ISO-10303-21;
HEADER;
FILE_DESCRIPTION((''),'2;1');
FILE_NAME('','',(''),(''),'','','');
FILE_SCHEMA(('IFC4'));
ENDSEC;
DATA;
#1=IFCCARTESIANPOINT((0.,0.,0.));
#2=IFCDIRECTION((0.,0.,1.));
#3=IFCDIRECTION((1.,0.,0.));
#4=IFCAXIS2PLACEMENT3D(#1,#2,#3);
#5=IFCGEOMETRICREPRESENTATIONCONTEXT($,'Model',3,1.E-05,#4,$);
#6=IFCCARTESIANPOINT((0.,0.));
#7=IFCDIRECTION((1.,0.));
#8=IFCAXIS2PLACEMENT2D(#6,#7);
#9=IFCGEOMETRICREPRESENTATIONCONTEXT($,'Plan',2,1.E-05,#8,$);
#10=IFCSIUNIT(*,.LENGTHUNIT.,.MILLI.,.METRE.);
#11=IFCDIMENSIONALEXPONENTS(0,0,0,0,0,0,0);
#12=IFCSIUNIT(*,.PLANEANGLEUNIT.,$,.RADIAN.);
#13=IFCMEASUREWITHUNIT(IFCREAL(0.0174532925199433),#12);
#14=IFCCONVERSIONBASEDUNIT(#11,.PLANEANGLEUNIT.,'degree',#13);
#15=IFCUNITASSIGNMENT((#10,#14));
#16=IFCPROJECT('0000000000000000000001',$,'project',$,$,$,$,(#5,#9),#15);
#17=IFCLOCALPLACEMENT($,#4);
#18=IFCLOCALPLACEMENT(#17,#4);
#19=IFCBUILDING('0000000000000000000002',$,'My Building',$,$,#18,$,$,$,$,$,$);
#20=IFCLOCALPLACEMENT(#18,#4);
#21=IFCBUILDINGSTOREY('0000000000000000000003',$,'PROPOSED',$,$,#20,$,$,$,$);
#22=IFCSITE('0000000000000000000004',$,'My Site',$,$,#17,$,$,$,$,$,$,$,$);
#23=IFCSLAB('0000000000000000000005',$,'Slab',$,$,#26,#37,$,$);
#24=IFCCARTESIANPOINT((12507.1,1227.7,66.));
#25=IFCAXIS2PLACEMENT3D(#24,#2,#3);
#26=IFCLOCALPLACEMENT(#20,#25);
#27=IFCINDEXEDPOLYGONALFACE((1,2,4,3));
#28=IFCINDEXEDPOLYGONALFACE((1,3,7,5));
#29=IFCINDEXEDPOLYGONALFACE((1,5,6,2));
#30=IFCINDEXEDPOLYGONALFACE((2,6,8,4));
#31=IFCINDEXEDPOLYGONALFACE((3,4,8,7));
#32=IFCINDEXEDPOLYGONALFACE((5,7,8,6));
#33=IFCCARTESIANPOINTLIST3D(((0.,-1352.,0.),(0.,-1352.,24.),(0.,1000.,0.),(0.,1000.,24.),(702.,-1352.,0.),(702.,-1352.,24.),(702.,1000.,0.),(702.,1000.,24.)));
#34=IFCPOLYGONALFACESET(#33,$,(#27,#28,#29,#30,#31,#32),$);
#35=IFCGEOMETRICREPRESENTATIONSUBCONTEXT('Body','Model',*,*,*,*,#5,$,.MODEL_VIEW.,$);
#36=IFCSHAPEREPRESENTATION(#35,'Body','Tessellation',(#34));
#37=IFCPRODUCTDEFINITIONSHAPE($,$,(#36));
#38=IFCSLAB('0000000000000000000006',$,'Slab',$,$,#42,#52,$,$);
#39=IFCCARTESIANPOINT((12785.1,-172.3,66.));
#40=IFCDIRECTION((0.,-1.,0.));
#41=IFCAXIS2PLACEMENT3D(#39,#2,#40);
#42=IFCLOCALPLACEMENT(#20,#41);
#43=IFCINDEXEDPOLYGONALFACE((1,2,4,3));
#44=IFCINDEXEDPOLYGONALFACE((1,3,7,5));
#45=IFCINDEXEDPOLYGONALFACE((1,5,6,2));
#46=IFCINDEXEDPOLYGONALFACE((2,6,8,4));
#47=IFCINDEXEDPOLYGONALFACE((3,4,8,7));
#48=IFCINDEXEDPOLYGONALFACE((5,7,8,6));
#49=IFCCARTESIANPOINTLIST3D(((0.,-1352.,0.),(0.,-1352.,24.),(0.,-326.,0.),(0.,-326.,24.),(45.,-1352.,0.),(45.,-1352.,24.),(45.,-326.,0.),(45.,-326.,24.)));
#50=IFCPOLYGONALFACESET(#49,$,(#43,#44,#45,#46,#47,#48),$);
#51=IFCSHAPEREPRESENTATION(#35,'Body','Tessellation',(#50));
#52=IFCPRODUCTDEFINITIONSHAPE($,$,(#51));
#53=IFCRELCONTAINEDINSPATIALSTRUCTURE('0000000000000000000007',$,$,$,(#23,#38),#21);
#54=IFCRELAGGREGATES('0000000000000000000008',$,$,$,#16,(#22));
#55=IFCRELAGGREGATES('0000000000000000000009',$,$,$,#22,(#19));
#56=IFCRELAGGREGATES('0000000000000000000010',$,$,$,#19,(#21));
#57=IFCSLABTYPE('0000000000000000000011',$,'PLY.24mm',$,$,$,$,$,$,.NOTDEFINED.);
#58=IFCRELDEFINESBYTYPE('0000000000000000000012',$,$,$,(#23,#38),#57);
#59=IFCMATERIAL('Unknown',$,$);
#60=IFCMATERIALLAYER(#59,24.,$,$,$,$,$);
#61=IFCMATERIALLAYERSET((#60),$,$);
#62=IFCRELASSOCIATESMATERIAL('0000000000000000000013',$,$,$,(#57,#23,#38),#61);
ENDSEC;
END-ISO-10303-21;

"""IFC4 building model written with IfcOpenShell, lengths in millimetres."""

from ifc_helpers import new_model, entity, si_unit, converted_unit, frame, origin_with_axes, origin_2d_with_axis, place, context, subcontext, project, spatial, line, indexed_curve, outline, extrude, material, layer, layer_set, layer_usage, type_object, element, save


model = new_model("IFC4")

# Units and contexts
model_context = context("Model", 3, precision=1e-05, world=origin_with_axes())
plan_context = context("Plan", 2, precision=1e-05, world=origin_2d_with_axis())
body_context = subcontext(model_context, "Body", "Model", "MODEL_VIEW")
ifc_project = project(units=[si_unit("LENGTHUNIT", "METRE", prefix="MILLI"), converted_unit("PLANEANGLEUNIT", "degree", entity("IfcReal", 0.0174532925199433), si_unit("PLANEANGLEUNIT", "RADIAN"), dimensions=[0, 0, 0, 0, 0, 0, 0])], contexts=[model_context, plan_context])

# Site, building, storey
site_placement = place(None, origin_with_axes())
site = spatial("IfcSite", under=ifc_project, at=site_placement, Name="My Site")
building_placement = place(site_placement, origin_with_axes())
building = spatial("IfcBuilding", under=site, at=building_placement, Name="My Building")
storey_placement = place(building_placement, origin_with_axes())
storey = spatial("IfcBuildingStorey", under=building, at=storey_placement, Name="PROPOSED")

# Slabs
ifc_material = material(Name="Unknown")
ifc_layer_1 = layer(ifc_material, 24.0)
ifc_layer_set_1 = layer_set([ifc_layer_1])
slab_type = type_object("IfcSlabType", Name="PLY.24mm", PredefinedType="NOTDEFINED", material=ifc_layer_set_1)
ifc_layer_usage_1 = layer_usage(ifc_layer_set_1, "AXIS3", "POSITIVE", 0.0)
slab_1_placement = place(storey_placement, frame((12507.1, 1227.7, 66.0), z_axis=(0.0, 0.0, 1.0), x_axis=(1.0, 0.0, 0.0)))
element("IfcSlab", 1, at=slab_1_placement, inside=storey, type_object=slab_type, material=ifc_layer_usage_1, Name="Slab", context=body_context, shape_type="SweptSolid", body=[
    extrude(outline(indexed_curve([(702.0, -1352.0), (702.0, 1000.0), (0.0, 1000.0), (0.0, -1352.0)], segments=[line(4, 1), line(1, 2), line(2, 3), line(3, 4)], self_intersect=False)), None, (0.0, 0.0, 1.0), 24.0),
])
ifc_layer_usage_2 = layer_usage(ifc_layer_set_1, "AXIS3", "POSITIVE", 0.0)
slab_2_placement = place(storey_placement, frame((12785.1, -172.3, 66.0), z_axis=(0.0, 0.0, 1.0), x_axis=(0.0, -1.0, 0.0)))
element("IfcSlab", 2, at=slab_2_placement, inside=storey, type_object=slab_type, material=ifc_layer_usage_2, Name="Slab", context=body_context, shape_type="SweptSolid", body=[
    extrude(outline(indexed_curve([(45.0, -326.0), (0.0, -326.0), (0.0, -1352.0), (45.0, -1352.0)], segments=[line(3, 2), line(2, 1), line(1, 4), line(4, 3)], self_intersect=False)), None, (0.0, 0.0, 1.0), 24.0),
])

save(model, "model.ifc")
